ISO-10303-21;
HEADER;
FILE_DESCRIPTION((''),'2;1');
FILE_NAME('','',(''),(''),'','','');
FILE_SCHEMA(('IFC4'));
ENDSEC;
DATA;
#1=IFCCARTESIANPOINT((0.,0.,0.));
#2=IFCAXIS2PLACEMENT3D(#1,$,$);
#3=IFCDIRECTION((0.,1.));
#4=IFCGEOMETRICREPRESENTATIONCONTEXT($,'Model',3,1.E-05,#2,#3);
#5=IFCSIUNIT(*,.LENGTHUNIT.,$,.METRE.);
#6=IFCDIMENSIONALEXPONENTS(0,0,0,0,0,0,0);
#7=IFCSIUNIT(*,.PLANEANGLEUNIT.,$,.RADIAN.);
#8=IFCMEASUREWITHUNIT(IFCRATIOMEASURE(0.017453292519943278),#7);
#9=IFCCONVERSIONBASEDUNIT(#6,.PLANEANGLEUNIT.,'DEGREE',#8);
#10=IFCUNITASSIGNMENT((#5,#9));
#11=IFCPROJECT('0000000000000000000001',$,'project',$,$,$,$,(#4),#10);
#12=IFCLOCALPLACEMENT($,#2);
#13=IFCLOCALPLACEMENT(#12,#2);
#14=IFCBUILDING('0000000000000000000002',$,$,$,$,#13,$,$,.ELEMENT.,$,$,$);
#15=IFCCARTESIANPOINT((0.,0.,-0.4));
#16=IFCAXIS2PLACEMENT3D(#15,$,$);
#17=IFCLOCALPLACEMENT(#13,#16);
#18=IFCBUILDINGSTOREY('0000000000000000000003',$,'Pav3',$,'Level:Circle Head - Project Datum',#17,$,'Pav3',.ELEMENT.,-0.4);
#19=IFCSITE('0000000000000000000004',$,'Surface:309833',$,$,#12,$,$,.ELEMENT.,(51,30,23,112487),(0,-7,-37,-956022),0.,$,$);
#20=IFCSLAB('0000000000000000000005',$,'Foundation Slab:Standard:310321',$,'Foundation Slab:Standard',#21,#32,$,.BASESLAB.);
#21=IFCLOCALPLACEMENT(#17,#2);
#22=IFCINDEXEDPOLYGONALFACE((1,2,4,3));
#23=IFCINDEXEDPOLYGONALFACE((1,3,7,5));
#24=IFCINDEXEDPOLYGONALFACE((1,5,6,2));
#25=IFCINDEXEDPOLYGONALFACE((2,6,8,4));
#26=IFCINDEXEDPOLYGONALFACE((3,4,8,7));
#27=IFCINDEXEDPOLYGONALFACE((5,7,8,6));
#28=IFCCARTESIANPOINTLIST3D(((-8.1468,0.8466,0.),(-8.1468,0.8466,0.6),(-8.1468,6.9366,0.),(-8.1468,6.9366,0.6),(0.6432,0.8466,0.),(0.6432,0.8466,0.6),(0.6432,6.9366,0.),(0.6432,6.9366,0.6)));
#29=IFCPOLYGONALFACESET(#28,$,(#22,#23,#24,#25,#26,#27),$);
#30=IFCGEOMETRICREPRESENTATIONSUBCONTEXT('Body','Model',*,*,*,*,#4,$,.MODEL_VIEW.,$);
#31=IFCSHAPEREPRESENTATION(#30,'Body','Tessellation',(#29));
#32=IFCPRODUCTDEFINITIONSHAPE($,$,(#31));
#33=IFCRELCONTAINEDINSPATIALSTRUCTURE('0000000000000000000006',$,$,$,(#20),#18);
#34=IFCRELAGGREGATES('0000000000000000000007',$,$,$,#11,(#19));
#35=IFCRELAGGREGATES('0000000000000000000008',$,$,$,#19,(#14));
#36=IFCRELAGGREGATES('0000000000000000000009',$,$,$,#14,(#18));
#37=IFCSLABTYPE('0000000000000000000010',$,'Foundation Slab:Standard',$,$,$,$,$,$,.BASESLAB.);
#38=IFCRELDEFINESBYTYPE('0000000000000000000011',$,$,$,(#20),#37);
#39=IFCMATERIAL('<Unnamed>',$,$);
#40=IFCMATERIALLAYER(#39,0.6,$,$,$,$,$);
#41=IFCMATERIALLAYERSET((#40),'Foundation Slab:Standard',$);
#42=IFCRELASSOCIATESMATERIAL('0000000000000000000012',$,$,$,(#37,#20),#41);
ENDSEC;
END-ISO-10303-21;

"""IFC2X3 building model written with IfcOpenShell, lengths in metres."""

from ifc_helpers import new_model, entity, si_unit, converted_unit, direction, frame, origin, origin_2d_with_axis, place, context, subcontext, project, spatial, rectangle, extrude, material, layer, layer_set, layer_usage, type_object, element, save


model = new_model("IFC2X3")

# Units and contexts
model_context = context("Model", 3, precision=1e-05, world=origin(), true_north=direction((0.0, 1.0)))
body_context = subcontext(model_context, "Body", "Model", "MODEL_VIEW")
ifc_project = project(units=[si_unit("LENGTHUNIT", "METRE"), converted_unit("PLANEANGLEUNIT", "DEGREE", entity("IfcRatioMeasure", 0.017453292519943278), si_unit("PLANEANGLEUNIT", "RADIAN"), dimensions=[0, 0, 0, 0, 0, 0, 0])], contexts=[model_context])

# Site, building, storey
site_placement = place(None, origin())
site = spatial("IfcSite", under=ifc_project, at=site_placement, Name="Surface:309833", CompositionType="ELEMENT", RefLatitude=(51, 30, 23, 112487), RefLongitude=(0, -7, -37, -956022), RefElevation=0.0)
building_placement = place(site_placement, origin())
building = spatial("IfcBuilding", under=site, at=building_placement, CompositionType="ELEMENT")
storey_placement = place(building_placement, frame((0.0, 0.0, -0.4)))
storey = spatial("IfcBuildingStorey", under=building, at=storey_placement, Name="Pav3", ObjectType="Level:Circle Head - Project Datum", LongName="Pav3", CompositionType="ELEMENT", Elevation=-0.4)

# Slab
ifc_material = material(Name="<Unnamed>")
ifc_layer = layer(ifc_material, 0.6)
ifc_layer_set = layer_set([ifc_layer], Name="Foundation Slab:Standard")
ifc_layer_usage = layer_usage(ifc_layer_set, "AXIS3", "POSITIVE", 0.0)
slab_type = type_object("IfcSlabType", Name="Foundation Slab:Standard", PredefinedType="BASESLAB", material=ifc_layer_set)
slab_placement = place(storey_placement, origin())
element("IfcSlab", 1, at=slab_placement, inside=storey, type_object=slab_type, material=ifc_layer_usage, Name="Foundation Slab:Standard:310321", ObjectType="Foundation Slab:Standard", PredefinedType="BASESLAB", context=body_context, shape_type="SweptSolid", body=[
    extrude(rectangle(XDim=6.09, YDim=8.79, at=origin_2d_with_axis()), frame((-3.7518, 3.8916, 0.6), z_axis=(0.0, 0.0, -1.0), x_axis=(0.0, 1.0, 0.0)), (0.0, 0.0, 1.0), 0.6),
])

save(model, "model.ifc")
